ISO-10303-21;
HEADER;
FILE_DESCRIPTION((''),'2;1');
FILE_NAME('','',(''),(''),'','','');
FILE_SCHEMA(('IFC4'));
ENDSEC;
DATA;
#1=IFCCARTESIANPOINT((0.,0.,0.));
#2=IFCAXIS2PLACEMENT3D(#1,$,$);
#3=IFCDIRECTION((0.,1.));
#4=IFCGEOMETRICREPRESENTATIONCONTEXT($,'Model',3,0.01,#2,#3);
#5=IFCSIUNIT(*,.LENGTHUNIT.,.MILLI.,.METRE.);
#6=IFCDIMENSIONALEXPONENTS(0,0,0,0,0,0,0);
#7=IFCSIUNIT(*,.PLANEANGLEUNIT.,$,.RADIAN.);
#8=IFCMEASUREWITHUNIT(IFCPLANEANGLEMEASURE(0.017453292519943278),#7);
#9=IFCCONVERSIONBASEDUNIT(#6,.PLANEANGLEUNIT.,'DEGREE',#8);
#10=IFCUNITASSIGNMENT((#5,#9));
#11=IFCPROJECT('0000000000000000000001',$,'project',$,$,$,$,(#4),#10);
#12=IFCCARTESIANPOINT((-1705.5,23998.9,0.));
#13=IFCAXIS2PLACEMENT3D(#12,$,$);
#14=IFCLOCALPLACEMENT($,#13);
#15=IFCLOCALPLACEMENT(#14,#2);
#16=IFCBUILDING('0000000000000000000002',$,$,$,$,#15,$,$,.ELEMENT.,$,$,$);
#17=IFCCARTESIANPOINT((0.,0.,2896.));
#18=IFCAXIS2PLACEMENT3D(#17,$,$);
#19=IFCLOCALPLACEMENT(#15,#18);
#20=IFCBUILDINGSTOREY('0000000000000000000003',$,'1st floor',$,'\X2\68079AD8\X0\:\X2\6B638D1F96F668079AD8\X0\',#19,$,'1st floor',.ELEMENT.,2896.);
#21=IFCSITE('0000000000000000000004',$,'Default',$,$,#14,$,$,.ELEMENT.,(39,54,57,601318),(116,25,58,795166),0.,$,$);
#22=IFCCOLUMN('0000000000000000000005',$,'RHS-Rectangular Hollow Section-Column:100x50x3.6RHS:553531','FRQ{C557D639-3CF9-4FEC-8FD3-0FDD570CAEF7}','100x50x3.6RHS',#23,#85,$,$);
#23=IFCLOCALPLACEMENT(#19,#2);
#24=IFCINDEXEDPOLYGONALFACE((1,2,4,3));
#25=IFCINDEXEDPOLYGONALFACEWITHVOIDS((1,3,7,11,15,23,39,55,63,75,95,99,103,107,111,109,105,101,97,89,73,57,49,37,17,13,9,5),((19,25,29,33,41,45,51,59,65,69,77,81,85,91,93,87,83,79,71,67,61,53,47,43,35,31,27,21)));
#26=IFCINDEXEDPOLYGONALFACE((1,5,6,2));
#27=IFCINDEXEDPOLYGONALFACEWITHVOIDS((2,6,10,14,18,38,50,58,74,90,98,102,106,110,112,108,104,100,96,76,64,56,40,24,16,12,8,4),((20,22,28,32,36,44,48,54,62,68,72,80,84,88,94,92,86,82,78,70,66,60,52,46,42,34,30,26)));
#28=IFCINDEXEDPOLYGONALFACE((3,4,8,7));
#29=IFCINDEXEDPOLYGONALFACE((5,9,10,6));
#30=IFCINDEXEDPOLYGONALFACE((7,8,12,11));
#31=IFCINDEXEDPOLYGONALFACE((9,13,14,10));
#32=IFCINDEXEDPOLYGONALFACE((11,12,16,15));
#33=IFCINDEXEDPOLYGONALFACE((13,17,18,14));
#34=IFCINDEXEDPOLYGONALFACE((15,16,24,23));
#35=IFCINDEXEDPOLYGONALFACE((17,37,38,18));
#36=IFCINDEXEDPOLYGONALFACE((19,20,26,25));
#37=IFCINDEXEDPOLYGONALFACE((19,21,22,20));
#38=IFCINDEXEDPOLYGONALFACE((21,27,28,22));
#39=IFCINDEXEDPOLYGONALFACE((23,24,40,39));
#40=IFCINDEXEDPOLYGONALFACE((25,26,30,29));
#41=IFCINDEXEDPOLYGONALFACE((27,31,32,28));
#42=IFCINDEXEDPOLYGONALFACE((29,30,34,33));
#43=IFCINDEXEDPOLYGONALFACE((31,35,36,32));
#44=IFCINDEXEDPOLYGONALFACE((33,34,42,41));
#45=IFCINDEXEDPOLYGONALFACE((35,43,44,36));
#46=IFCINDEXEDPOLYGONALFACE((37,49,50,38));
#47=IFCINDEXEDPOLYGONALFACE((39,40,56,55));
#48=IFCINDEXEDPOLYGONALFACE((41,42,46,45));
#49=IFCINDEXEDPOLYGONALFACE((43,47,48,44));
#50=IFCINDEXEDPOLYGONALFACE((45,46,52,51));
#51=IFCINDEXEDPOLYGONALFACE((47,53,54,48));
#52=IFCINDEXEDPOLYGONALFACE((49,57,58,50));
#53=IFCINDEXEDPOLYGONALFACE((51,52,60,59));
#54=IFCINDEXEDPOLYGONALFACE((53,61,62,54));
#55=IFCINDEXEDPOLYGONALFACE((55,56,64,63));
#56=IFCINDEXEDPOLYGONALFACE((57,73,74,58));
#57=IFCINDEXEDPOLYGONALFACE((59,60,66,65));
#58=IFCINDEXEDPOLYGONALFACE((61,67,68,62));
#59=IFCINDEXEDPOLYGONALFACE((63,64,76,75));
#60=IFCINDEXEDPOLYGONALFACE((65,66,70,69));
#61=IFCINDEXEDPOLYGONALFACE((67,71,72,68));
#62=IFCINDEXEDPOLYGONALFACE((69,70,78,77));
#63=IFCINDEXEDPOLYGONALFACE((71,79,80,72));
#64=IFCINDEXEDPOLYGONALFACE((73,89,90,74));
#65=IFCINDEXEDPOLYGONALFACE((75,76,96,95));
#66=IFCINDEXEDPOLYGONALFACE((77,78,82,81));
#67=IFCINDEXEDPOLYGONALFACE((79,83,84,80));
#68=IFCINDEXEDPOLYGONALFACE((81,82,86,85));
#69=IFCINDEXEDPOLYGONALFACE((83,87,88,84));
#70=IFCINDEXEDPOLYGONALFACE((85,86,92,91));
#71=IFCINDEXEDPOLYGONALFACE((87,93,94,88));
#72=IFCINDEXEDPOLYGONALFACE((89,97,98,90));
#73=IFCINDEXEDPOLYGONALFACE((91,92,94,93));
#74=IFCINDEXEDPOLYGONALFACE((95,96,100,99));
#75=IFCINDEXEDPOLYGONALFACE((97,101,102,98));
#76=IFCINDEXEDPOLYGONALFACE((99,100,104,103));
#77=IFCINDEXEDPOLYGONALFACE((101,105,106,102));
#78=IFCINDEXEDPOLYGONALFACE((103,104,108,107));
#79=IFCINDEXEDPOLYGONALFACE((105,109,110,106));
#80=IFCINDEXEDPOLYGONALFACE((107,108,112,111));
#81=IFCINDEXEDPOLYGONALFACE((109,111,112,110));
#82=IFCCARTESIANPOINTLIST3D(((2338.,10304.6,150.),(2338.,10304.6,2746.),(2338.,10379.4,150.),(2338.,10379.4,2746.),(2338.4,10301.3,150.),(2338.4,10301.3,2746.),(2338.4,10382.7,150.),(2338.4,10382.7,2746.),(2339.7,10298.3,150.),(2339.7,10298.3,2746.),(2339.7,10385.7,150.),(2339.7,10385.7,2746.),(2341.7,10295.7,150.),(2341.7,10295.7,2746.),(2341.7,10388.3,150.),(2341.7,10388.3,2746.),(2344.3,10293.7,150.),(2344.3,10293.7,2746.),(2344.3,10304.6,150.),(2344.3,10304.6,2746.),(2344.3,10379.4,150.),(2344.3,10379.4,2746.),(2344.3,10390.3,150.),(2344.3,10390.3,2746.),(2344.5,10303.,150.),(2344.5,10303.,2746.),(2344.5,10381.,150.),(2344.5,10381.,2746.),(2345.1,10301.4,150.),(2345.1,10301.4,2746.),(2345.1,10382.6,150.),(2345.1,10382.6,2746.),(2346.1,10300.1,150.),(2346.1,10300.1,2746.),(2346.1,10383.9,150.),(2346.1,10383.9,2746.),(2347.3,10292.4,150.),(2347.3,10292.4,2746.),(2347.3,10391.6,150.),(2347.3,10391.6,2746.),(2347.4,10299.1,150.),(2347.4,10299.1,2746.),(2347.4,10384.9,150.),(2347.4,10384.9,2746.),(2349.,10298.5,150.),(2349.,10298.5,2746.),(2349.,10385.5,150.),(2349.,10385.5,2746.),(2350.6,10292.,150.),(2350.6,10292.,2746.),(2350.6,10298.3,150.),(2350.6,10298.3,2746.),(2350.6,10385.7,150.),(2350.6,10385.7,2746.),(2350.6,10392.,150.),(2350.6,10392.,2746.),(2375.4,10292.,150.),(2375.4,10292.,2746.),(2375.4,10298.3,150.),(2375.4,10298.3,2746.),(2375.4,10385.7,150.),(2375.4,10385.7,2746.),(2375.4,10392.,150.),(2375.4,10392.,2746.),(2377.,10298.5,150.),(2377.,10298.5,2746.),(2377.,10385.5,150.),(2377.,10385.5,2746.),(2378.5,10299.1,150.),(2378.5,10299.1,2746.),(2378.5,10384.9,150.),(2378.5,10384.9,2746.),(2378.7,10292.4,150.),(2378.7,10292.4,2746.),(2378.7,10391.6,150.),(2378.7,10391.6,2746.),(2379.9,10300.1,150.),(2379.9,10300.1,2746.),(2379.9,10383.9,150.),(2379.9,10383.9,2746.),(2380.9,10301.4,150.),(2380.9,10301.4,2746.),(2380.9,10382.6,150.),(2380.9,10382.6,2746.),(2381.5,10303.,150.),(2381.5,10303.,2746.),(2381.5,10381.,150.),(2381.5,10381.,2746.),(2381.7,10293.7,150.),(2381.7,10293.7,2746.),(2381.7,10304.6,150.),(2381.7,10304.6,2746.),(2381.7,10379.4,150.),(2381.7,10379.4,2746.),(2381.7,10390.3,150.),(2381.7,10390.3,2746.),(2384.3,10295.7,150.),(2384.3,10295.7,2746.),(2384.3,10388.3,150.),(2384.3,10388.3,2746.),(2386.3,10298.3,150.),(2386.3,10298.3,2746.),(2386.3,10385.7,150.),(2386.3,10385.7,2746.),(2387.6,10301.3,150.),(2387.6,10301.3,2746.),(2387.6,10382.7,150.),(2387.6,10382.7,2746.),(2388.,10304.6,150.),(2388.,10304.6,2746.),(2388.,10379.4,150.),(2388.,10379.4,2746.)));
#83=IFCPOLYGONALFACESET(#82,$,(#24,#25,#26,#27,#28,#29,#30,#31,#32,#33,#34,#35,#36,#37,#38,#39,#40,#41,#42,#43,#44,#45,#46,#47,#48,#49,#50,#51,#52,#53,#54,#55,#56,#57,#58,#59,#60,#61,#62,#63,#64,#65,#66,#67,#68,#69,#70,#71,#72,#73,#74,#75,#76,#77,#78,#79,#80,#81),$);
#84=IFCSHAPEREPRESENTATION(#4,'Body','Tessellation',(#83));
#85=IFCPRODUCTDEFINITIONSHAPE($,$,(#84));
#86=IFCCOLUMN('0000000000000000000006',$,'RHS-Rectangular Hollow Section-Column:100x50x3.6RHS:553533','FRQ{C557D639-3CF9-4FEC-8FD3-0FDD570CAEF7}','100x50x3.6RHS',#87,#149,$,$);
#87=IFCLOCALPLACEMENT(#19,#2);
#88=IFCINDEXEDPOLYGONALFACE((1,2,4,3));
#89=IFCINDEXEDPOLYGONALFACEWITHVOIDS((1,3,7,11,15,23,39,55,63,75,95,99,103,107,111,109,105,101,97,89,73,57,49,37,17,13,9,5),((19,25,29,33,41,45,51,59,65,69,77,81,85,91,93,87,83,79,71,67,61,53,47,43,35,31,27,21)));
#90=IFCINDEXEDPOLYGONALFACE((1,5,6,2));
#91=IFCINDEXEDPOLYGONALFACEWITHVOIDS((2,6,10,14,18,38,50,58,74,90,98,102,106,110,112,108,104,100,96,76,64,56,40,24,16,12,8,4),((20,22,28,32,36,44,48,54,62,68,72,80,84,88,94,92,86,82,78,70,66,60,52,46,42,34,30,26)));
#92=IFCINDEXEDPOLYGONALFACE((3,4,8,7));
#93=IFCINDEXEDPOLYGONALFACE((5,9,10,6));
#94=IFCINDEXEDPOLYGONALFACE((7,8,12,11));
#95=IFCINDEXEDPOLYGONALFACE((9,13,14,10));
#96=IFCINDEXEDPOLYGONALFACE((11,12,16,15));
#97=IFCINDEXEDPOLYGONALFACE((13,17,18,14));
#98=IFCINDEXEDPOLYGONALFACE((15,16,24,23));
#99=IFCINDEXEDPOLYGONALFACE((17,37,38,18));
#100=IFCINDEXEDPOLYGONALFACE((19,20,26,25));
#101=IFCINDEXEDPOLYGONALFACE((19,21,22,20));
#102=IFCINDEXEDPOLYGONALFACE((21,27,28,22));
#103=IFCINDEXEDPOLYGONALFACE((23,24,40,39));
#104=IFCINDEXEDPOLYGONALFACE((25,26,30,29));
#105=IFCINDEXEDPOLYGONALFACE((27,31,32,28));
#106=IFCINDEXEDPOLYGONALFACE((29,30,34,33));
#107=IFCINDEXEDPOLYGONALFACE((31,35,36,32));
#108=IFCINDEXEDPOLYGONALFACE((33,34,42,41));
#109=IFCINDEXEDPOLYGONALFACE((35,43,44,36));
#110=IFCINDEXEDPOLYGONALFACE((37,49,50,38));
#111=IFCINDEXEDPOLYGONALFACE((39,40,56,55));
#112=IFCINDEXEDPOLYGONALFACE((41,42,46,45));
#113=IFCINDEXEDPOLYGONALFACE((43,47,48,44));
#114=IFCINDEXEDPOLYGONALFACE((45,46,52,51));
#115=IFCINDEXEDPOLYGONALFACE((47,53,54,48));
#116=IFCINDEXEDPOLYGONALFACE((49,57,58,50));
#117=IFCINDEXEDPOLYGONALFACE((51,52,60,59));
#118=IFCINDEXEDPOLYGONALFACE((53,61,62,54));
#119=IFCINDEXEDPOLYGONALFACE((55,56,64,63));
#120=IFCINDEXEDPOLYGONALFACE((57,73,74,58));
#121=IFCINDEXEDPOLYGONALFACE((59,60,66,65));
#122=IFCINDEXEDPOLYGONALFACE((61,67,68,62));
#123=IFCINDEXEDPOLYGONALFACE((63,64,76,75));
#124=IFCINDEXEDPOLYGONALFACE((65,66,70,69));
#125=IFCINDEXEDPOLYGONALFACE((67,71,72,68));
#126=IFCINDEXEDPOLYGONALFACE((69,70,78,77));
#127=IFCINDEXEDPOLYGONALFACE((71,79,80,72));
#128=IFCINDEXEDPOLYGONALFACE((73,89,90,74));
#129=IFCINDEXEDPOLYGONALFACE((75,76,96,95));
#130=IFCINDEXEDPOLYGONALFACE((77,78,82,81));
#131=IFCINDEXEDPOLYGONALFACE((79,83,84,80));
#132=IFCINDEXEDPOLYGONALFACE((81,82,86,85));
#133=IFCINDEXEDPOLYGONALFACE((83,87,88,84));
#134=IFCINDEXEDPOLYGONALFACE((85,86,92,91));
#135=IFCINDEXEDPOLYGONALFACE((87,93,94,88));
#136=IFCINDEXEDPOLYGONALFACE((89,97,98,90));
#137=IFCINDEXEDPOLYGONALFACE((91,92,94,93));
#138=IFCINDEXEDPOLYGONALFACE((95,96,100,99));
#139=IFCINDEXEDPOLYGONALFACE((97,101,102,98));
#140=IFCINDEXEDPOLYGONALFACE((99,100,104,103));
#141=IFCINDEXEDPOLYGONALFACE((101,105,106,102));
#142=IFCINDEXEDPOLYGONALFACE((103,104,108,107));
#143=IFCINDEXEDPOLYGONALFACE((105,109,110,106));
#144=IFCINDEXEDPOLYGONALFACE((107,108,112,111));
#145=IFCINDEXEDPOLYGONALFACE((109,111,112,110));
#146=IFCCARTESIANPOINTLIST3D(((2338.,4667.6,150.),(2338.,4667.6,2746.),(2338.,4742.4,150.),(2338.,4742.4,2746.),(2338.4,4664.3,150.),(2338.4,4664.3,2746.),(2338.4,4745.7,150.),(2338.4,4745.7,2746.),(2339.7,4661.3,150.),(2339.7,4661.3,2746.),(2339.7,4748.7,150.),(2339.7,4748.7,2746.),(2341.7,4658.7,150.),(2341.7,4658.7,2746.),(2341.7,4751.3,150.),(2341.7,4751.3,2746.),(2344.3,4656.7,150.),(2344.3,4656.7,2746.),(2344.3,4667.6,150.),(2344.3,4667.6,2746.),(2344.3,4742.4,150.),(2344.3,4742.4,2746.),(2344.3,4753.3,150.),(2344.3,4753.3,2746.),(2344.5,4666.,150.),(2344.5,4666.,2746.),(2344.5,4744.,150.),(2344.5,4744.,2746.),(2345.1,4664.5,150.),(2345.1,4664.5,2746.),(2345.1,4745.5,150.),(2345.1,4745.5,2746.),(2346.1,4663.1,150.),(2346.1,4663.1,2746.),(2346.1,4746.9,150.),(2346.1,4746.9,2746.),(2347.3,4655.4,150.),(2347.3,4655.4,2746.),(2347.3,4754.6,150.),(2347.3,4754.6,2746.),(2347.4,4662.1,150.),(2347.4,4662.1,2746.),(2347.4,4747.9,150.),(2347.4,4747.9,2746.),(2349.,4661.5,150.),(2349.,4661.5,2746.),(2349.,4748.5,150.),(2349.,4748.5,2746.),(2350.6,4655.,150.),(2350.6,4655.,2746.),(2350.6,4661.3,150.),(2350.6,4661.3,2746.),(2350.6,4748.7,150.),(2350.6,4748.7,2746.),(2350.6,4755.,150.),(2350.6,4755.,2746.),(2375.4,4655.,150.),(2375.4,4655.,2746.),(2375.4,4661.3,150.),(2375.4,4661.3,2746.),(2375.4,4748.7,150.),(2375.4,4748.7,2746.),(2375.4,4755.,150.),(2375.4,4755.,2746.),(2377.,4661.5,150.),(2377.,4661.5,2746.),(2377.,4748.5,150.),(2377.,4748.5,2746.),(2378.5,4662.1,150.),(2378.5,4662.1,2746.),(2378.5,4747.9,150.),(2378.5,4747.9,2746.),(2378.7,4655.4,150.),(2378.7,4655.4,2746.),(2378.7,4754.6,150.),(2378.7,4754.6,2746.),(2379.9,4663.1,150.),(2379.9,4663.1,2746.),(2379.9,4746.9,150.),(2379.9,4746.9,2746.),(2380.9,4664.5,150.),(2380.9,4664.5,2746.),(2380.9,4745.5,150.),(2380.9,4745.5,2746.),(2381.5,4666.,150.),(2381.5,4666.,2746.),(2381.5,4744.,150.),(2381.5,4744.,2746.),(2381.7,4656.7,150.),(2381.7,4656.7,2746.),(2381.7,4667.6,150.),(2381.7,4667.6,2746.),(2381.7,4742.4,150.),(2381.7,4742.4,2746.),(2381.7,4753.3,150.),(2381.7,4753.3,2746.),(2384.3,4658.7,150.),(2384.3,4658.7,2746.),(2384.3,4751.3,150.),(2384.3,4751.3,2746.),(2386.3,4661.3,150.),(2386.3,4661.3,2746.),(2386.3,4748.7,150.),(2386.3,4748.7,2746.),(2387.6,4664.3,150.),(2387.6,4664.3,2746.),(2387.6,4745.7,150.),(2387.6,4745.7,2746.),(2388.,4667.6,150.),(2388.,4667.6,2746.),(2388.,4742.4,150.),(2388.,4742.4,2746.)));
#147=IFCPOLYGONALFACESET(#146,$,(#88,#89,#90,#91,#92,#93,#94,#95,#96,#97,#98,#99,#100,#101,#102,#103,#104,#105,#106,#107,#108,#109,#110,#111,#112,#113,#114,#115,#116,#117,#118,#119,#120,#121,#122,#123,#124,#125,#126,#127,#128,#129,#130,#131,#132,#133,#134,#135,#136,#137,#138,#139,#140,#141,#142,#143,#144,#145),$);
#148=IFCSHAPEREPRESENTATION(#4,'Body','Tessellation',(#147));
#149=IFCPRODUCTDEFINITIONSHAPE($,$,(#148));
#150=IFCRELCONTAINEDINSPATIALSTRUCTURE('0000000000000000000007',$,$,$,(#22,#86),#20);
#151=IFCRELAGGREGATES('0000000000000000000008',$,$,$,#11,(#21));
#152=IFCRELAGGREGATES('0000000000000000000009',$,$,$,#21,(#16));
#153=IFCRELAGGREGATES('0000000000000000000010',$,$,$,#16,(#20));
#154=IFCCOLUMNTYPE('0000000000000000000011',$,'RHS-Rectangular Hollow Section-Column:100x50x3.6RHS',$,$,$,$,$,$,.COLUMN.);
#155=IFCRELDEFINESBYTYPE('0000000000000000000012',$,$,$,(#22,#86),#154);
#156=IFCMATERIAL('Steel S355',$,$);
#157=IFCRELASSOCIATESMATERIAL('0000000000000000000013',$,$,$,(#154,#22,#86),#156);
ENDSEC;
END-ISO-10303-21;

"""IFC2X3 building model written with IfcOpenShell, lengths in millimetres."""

from ifc_helpers import new_model, entity, si_unit, converted_unit, direction, frame, origin, origin_2d, place, context, project, spatial, hollow_rectangle, extrude, clip, halfspace, material, type_object, element, save


model = new_model("IFC2X3")

# Units and contexts
model_context = context("Model", 3, precision=0.01, world=origin(), true_north=direction((0.0, 1.0)))
ifc_project = project(units=[si_unit("LENGTHUNIT", "METRE", prefix="MILLI"), converted_unit("PLANEANGLEUNIT", "DEGREE", entity("IfcPlaneAngleMeasure", 0.017453292519943278), si_unit("PLANEANGLEUNIT", "RADIAN"), dimensions=[0, 0, 0, 0, 0, 0, 0])], contexts=[model_context])

# Site, building, storey
site_placement = place(None, frame((-1705.5, 23998.9, 0.0)))
site = spatial("IfcSite", under=ifc_project, at=site_placement, Name="Default", CompositionType="ELEMENT", RefLatitude=(39, 54, 57, 601318), RefLongitude=(116, 25, 58, 795166), RefElevation=0.0)
building_placement = place(site_placement, origin())
building = spatial("IfcBuilding", under=site, at=building_placement, CompositionType="ELEMENT")
storey_placement = place(building_placement, frame((0.0, 0.0, 2896.0)))
storey = spatial("IfcBuildingStorey", under=building, at=storey_placement, Name="1st floor", ObjectType="标高:正负零标高", LongName="1st floor", CompositionType="ELEMENT", Elevation=2896.0)

# Columns
ifc_material_1 = material(Name="Steel S355")
column_type = type_object("IfcColumnType", Name="RHS-Rectangular Hollow Section-Column:100x50x3.6RHS", PredefinedType="COLUMN", material=ifc_material_1)
column_1_placement = place(storey_placement, frame((2363.0, 10342.0, 2746.0), z_axis=(0.0, 0.0, 1.0), x_axis=(-1.0, 0.0, 0.0)))
element("IfcColumn", 1, at=column_1_placement, inside=storey, type_object=column_type, material=ifc_material_1, Name="RHS-Rectangular Hollow Section-Column:100x50x3.6RHS:553531", Description="FRQ{C557D639-3CF9-4FEC-8FD3-0FDD570CAEF7}", ObjectType="100x50x3.6RHS", context=model_context, shape_type="Clipping", body=[
    clip(extrude(hollow_rectangle(XDim=50.0, YDim=100.0, WallThickness=6.3, InnerFilletRadius=6.3, OuterFilletRadius=12.6, at=origin_2d()), origin(), (0.0, 0.0, -1.0), 2651.9), halfspace(frame((2363.0, 10342.0, -2596.0), z_axis=(0.0, 0.0, 1.0), x_axis=(-1.0, 0.0, 0.0)), True)),
])
column_2_placement = place(storey_placement, frame((2363.0, 4705.0, 2746.0), z_axis=(0.0, 0.0, 1.0), x_axis=(-1.0, 0.0, 0.0)))
element("IfcColumn", 2, at=column_2_placement, inside=storey, type_object=column_type, material=ifc_material_1, Name="RHS-Rectangular Hollow Section-Column:100x50x3.6RHS:553533", Description="FRQ{C557D639-3CF9-4FEC-8FD3-0FDD570CAEF7}", ObjectType="100x50x3.6RHS", context=model_context, shape_type="Clipping", body=[
    clip(extrude(hollow_rectangle(XDim=50.0, YDim=100.0, WallThickness=6.3, InnerFilletRadius=6.3, OuterFilletRadius=12.6, at=origin_2d()), origin(), (0.0, 0.0, -1.0), 2651.9), halfspace(frame((2363.0, 4705.0, -2596.0), z_axis=(0.0, 0.0, 1.0), x_axis=(-1.0, 0.0, 0.0)), True)),
])

save(model, "model.ifc")
